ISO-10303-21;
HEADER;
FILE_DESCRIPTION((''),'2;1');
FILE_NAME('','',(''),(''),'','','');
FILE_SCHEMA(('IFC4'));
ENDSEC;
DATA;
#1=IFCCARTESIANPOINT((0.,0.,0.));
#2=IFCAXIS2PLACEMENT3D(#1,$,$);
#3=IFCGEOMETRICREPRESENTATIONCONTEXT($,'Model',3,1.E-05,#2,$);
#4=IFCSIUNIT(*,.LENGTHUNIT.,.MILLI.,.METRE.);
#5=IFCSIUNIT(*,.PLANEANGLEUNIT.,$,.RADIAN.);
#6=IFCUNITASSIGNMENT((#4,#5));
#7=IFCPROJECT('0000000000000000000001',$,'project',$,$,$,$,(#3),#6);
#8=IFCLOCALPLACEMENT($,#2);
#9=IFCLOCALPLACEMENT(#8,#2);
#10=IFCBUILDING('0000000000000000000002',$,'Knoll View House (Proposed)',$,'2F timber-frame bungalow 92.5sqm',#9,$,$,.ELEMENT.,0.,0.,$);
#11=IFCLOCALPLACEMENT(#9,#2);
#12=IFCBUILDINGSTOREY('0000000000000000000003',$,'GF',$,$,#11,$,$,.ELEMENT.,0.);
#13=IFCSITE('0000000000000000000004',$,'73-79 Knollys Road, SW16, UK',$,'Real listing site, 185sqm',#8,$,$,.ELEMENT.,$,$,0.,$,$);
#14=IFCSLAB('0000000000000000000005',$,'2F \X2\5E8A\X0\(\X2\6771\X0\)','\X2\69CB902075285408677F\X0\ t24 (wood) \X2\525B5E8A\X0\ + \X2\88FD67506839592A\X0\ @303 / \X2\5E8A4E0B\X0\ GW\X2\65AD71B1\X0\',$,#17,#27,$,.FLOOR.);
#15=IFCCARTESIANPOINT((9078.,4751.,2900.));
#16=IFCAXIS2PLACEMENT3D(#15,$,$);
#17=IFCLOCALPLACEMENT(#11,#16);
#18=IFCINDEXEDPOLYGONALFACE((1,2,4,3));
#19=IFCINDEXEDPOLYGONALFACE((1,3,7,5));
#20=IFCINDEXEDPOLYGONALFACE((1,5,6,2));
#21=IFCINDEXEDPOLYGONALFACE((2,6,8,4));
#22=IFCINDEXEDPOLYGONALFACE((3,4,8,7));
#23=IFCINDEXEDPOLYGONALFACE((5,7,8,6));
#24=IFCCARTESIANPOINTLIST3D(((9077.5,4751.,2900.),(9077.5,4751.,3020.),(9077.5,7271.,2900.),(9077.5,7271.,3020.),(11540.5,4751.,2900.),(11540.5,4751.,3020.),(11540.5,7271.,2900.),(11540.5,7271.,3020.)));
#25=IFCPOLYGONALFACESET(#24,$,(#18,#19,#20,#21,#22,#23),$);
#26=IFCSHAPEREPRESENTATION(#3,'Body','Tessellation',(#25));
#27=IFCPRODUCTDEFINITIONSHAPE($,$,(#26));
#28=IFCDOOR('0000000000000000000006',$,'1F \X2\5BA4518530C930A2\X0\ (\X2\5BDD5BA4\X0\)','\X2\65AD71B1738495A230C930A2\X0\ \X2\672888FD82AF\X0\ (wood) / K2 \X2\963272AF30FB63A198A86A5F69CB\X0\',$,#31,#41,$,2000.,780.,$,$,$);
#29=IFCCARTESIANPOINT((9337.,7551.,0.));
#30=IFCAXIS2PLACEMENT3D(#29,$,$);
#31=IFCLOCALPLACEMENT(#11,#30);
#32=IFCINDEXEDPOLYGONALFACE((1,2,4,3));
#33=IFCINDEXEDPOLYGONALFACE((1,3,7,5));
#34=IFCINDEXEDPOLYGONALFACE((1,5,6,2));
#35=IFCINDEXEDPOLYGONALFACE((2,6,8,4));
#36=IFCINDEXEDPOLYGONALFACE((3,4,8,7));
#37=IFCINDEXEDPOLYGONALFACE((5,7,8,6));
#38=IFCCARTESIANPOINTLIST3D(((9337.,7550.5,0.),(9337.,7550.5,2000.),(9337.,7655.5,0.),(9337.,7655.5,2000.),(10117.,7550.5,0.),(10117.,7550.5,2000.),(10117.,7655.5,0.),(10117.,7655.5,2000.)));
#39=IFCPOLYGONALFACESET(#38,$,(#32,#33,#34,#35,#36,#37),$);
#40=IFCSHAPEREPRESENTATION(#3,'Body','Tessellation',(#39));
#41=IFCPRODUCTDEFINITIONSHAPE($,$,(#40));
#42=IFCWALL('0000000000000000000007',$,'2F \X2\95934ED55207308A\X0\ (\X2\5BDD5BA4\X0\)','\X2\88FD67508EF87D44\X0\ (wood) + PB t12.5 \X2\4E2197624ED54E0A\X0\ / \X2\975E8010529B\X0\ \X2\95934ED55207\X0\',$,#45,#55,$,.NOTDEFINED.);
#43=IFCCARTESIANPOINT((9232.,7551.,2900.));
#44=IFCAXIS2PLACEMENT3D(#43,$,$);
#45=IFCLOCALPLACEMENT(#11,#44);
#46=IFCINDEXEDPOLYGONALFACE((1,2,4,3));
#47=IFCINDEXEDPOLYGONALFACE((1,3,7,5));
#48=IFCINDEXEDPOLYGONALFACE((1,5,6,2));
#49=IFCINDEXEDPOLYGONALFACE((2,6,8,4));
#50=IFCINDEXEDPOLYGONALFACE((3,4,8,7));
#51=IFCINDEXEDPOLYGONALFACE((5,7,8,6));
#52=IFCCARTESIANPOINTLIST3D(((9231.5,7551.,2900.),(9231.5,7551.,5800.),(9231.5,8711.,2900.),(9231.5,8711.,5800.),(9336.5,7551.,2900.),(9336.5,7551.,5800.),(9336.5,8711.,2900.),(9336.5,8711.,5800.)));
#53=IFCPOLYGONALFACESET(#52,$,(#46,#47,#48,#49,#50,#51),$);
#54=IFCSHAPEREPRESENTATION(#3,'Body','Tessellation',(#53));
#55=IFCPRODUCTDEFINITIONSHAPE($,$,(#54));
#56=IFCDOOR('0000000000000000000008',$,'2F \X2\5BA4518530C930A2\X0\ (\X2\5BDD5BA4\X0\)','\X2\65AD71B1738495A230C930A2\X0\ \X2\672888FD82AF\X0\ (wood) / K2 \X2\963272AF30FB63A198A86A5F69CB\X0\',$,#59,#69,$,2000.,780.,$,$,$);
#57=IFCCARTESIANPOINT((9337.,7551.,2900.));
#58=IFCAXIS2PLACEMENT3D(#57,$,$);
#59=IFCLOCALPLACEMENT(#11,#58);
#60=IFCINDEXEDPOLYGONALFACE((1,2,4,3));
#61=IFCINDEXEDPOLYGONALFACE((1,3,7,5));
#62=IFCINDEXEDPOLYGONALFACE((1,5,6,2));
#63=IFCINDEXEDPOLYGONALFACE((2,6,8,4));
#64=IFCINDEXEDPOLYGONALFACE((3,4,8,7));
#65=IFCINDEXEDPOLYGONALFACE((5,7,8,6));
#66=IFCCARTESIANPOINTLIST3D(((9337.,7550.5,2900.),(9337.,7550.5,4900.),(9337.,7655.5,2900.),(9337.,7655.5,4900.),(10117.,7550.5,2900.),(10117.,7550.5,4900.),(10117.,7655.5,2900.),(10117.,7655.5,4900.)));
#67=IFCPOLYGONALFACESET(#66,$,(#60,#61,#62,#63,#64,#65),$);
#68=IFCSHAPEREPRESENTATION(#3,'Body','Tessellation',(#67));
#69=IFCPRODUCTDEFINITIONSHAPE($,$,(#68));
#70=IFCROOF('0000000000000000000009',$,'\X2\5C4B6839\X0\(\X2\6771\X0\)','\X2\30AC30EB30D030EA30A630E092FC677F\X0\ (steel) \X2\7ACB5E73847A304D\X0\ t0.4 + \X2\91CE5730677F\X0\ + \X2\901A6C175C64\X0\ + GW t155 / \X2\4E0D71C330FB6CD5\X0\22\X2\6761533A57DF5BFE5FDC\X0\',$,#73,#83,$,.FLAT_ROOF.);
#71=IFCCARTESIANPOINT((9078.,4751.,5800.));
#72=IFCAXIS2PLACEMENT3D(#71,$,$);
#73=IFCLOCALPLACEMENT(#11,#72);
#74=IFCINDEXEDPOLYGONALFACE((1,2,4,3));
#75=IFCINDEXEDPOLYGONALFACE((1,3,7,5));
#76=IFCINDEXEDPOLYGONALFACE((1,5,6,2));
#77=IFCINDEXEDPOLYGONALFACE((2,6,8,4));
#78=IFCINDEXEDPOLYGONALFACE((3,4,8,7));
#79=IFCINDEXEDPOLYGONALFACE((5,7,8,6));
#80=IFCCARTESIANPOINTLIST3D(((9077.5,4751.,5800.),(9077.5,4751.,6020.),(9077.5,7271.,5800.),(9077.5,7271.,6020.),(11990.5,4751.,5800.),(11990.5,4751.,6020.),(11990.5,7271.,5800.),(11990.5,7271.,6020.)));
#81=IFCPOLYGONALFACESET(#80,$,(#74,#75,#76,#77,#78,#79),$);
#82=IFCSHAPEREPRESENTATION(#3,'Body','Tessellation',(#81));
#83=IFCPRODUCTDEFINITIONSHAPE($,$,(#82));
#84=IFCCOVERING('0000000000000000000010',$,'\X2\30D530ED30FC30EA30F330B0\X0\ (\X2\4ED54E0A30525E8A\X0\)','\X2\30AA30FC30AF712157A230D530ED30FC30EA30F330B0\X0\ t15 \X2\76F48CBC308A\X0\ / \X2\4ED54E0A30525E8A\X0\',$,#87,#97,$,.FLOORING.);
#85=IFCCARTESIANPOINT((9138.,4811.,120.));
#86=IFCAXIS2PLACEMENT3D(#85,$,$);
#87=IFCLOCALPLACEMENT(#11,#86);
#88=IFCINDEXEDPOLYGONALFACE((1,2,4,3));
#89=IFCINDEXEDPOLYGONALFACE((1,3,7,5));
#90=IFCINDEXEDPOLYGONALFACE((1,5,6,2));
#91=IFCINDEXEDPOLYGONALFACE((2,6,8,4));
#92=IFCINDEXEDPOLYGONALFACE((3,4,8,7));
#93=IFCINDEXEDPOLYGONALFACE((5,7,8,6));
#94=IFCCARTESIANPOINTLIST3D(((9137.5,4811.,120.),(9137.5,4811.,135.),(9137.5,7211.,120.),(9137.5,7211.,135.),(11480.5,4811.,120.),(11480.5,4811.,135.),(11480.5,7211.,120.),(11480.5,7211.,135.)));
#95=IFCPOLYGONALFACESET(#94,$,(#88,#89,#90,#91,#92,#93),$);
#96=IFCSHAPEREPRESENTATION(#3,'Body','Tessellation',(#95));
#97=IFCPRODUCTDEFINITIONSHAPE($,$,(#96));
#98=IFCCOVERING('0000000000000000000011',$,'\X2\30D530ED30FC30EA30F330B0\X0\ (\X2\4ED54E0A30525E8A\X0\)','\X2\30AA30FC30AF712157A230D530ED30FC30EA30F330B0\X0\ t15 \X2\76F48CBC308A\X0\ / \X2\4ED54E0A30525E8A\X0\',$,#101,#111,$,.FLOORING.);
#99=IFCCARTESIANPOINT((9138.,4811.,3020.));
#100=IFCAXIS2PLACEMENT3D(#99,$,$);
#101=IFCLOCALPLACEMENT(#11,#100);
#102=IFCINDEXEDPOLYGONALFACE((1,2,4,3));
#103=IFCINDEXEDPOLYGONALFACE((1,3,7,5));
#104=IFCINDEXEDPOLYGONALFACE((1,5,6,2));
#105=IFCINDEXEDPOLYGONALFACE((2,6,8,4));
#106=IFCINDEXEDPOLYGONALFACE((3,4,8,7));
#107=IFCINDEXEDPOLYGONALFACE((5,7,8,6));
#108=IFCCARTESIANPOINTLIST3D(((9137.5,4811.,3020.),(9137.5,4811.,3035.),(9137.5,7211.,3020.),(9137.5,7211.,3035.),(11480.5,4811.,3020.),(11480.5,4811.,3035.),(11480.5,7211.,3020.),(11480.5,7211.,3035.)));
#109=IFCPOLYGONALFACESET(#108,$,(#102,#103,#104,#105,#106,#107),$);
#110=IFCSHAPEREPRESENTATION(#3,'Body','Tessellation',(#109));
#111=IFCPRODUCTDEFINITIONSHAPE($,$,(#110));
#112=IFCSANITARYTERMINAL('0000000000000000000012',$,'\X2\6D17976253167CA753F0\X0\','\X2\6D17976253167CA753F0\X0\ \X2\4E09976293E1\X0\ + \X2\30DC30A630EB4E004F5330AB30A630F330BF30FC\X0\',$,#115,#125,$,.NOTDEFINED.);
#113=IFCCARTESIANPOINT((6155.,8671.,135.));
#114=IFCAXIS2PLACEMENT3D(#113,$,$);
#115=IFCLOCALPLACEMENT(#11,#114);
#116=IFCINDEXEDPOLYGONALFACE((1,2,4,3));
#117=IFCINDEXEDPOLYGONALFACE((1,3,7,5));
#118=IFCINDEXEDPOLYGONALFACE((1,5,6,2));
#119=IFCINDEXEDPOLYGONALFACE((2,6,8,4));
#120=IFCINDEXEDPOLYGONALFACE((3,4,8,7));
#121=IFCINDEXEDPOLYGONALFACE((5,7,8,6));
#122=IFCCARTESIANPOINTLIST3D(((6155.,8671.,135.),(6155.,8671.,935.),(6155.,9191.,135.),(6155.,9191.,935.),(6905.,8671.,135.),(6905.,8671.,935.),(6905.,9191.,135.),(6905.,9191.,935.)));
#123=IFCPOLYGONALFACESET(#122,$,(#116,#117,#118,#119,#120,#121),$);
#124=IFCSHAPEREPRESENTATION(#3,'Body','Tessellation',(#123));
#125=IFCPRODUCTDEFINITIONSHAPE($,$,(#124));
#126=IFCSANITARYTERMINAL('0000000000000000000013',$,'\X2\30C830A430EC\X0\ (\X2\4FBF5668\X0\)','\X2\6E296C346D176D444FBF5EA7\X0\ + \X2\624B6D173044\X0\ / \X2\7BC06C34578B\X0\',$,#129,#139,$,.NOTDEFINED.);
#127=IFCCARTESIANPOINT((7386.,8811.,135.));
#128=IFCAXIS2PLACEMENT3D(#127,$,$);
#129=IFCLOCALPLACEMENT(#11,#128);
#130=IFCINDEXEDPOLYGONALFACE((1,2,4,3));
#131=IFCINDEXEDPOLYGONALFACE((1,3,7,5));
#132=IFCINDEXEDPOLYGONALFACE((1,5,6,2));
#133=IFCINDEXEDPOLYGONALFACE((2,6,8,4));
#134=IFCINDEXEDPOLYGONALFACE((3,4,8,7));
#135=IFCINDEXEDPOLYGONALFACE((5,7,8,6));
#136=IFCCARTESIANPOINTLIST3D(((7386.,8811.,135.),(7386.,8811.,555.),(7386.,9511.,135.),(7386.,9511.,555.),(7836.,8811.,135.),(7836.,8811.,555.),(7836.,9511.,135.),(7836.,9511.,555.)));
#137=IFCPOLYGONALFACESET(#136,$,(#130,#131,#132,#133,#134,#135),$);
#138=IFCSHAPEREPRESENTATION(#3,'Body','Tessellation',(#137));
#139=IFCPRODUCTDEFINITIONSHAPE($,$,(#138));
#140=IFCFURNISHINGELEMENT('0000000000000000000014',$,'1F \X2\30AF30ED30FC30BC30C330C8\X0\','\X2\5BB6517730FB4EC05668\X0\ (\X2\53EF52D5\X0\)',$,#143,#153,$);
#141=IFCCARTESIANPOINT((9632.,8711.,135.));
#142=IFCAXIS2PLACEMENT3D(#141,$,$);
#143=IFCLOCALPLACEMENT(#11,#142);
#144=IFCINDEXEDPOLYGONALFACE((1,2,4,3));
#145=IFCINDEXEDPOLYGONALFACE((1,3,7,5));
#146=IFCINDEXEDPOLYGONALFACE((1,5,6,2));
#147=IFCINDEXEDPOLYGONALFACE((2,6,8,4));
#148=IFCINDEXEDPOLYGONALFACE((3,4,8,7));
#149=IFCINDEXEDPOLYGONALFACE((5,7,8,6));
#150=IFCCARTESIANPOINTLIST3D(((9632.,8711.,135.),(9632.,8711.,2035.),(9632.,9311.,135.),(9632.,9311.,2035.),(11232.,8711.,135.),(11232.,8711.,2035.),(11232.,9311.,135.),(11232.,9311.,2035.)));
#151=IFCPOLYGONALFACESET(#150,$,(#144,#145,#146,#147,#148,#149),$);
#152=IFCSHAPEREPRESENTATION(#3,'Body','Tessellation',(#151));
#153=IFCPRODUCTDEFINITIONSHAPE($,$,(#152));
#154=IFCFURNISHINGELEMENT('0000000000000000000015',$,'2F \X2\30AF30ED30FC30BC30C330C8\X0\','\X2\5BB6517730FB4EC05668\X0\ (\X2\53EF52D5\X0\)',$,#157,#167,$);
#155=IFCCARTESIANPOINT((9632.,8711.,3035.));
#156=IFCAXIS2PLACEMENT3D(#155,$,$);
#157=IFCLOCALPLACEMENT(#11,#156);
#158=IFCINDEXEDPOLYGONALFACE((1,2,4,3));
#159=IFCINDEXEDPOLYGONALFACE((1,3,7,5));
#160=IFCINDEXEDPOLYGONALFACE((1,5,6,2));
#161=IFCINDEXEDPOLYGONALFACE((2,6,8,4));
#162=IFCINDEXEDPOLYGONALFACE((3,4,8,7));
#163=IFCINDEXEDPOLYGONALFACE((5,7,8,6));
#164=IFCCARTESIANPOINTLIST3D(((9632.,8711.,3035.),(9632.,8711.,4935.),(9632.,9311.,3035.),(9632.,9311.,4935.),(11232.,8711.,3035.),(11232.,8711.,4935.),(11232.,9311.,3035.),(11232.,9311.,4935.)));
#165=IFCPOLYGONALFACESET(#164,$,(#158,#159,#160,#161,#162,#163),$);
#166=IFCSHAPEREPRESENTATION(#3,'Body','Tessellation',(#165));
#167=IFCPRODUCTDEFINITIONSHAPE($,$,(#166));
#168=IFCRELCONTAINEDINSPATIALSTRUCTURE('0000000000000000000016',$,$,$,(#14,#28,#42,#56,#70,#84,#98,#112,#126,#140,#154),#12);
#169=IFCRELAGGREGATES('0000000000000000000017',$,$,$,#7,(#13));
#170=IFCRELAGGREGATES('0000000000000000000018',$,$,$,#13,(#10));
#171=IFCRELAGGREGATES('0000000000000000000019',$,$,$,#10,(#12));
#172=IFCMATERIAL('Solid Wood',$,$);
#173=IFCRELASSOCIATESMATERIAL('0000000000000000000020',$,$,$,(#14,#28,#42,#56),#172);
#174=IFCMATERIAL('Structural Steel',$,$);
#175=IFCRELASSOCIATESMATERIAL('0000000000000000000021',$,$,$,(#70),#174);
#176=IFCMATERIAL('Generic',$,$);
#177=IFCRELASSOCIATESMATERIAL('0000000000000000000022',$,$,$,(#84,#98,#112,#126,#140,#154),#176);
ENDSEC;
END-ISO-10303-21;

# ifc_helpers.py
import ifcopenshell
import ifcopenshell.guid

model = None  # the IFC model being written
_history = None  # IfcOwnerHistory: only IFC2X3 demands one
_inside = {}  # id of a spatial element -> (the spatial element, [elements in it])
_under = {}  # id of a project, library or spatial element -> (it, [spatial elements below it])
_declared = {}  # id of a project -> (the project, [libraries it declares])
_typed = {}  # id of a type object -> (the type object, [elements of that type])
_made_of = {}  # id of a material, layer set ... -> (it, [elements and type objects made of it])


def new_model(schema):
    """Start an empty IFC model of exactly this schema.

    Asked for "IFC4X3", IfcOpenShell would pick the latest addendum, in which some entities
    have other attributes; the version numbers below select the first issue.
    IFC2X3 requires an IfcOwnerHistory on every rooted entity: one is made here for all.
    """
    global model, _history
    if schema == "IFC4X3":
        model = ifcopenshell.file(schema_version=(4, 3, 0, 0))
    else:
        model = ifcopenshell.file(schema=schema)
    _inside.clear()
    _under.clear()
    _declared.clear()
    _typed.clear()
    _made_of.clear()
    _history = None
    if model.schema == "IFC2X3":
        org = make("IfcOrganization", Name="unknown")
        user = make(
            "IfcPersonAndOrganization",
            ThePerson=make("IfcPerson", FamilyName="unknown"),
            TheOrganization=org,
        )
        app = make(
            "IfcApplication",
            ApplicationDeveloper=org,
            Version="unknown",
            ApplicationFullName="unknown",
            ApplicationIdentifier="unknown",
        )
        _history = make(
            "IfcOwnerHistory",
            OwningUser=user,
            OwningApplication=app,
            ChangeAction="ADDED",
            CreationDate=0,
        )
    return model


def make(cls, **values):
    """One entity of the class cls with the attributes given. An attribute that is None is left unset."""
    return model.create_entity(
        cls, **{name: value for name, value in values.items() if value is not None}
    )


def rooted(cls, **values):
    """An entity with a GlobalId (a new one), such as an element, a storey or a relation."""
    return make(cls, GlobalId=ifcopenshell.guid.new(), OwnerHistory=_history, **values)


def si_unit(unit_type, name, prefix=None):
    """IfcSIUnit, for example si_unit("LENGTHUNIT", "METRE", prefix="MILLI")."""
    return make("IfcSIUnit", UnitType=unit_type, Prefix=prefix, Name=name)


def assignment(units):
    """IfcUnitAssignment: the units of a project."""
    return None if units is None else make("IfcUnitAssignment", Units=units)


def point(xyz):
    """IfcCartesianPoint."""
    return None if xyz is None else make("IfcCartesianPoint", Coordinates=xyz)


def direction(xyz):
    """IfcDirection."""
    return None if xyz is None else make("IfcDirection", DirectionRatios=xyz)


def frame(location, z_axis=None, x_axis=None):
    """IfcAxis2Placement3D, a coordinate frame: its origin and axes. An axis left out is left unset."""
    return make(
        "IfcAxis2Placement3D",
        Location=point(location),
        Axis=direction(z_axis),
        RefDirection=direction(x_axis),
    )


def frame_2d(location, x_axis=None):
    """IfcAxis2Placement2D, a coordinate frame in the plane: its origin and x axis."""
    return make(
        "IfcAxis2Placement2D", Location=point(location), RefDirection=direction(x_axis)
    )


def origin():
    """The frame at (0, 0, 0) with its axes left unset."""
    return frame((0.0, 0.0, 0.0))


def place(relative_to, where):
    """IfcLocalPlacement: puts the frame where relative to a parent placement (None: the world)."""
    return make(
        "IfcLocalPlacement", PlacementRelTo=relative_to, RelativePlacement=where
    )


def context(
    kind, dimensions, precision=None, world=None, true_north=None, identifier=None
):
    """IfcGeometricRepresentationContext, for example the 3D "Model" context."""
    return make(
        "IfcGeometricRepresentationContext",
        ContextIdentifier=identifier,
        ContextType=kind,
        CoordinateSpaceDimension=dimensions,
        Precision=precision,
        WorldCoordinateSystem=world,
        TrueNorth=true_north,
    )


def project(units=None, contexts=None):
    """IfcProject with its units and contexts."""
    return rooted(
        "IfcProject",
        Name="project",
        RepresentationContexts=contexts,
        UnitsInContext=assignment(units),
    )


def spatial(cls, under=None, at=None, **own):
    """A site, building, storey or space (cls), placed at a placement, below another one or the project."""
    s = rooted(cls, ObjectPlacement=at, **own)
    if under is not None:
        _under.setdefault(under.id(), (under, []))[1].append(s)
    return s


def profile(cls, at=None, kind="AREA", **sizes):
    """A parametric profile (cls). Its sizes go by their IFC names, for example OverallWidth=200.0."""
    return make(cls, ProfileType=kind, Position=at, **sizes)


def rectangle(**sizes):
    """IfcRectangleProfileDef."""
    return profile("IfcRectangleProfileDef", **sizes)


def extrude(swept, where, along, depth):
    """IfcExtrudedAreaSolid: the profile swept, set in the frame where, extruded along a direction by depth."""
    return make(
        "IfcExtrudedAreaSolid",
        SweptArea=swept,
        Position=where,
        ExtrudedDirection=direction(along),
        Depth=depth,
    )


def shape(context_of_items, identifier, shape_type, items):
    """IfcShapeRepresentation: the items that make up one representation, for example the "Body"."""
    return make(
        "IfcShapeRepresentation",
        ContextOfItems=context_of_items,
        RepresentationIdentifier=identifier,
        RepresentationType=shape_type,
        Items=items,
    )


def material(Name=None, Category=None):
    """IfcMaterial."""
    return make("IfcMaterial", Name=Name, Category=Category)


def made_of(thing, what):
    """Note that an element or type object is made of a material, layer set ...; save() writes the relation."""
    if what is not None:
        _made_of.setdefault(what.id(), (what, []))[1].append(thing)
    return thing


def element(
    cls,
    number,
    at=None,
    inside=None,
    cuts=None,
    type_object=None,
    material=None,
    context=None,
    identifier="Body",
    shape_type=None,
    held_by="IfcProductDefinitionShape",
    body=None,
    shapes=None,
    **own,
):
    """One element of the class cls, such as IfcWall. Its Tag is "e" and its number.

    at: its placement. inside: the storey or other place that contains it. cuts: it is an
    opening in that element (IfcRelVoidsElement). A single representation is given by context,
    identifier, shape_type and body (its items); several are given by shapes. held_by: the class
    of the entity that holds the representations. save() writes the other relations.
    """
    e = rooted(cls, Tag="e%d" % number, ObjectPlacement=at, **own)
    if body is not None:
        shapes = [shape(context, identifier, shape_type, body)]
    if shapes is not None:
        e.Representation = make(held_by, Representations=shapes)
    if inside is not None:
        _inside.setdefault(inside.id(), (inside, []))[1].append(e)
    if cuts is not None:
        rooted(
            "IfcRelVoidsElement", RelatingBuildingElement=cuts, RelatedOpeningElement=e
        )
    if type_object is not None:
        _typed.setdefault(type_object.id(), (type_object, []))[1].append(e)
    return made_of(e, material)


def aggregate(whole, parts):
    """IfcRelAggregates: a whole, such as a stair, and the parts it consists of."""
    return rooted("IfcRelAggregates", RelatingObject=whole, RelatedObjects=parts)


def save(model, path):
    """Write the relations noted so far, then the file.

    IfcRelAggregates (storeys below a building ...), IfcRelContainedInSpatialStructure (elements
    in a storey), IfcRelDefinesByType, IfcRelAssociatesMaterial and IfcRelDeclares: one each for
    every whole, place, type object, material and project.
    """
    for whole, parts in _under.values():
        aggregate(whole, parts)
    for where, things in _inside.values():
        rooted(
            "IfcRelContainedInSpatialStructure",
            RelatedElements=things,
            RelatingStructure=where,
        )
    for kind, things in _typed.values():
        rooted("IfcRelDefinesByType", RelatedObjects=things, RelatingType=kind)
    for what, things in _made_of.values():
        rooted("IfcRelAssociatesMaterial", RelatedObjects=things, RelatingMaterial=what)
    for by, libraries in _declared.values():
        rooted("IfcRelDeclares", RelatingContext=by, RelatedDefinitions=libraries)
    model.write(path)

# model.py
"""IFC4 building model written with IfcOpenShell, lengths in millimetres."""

from ifc_helpers import new_model, si_unit, frame, frame_2d, origin, place, context, project, spatial, rectangle, extrude, material, element, save


model = new_model("IFC4")

# Units and contexts
model_context = context("Model", 3, precision=1e-05, world=origin())
ifc_project = project(units=[si_unit("LENGTHUNIT", "METRE", prefix="MILLI"), si_unit("PLANEANGLEUNIT", "RADIAN")], contexts=[model_context])

# Site, building, storey
site_placement = place(None, origin())
site = spatial("IfcSite", under=ifc_project, at=site_placement, Name="73-79 Knollys Road, SW16, UK", ObjectType="Real listing site, 185sqm", CompositionType="ELEMENT", RefElevation=0.0)
building_placement = place(site_placement, origin())
building = spatial("IfcBuilding", under=site, at=building_placement, Name="Knoll View House (Proposed)", ObjectType="2F timber-frame bungalow 92.5sqm", CompositionType="ELEMENT", ElevationOfRefHeight=0.0, ElevationOfTerrain=0.0)
storey_placement = place(building_placement, origin())
storey = spatial("IfcBuildingStorey", under=building, at=storey_placement, Name="GF", CompositionType="ELEMENT", Elevation=0.0)

# Slab
ifc_material_1 = material(Name="Solid Wood")
slab_1_placement = place(storey_placement, frame((9078.0, 4751.0, 2900.0)))
element("IfcSlab", 1, at=slab_1_placement, inside=storey, material=ifc_material_1, Name="2F 床(東)", Description="構造用合板 t24 (wood) 剛床 + 製材根太 @303 / 床下 GW断熱", PredefinedType="FLOOR", context=model_context, shape_type="SweptSolid", body=[
    extrude(rectangle(XDim=2463.0, YDim=2520.0, at=frame_2d((1231.0, 1260.0))), frame((9078.0, 4751.0, 2900.0)), (0.0, 0.0, 1.0), 120.0),
])

# Door
door_1_placement = place(storey_placement, frame((9337.0, 7551.0, 0.0)))
element("IfcDoor", 2, at=door_1_placement, inside=storey, material=ifc_material_1, Name="1F 室内ドア (寝室)", Description="断熱玄関ドア 木製芯 (wood) / K2 防犯・採風機構", OverallHeight=2000.0, OverallWidth=780.0, context=model_context, shape_type="SweptSolid", body=[
    extrude(rectangle(XDim=780.0, YDim=105.0, at=frame_2d((390.0, 52.0))), frame((9337.0, 7551.0, 0.0)), (0.0, 0.0, 1.0), 2000.0),
])

# Wall
wall_1_placement = place(storey_placement, frame((9232.0, 7551.0, 2900.0)))
element("IfcWall", 3, at=wall_1_placement, inside=storey, material=ifc_material_1, Name="2F 間仕切り (寝室)", Description="製材軸組 (wood) + PB t12.5 両面仕上 / 非耐力 間仕切", PredefinedType="NOTDEFINED", context=model_context, shape_type="SweptSolid", body=[
    extrude(rectangle(XDim=105.0, YDim=1160.0, at=frame_2d((52.0, 580.0))), frame((9232.0, 7551.0, 2900.0)), (0.0, 0.0, 1.0), 2900.0),
])

# Door
door_2_placement = place(storey_placement, frame((9337.0, 7551.0, 2900.0)))
element("IfcDoor", 4, at=door_2_placement, inside=storey, material=ifc_material_1, Name="2F 室内ドア (寝室)", Description="断熱玄関ドア 木製芯 (wood) / K2 防犯・採風機構", OverallHeight=2000.0, OverallWidth=780.0, context=model_context, shape_type="SweptSolid", body=[
    extrude(rectangle(XDim=780.0, YDim=105.0, at=frame_2d((390.0, 52.0))), frame((9337.0, 7551.0, 2900.0)), (0.0, 0.0, 1.0), 2000.0),
])

# Roof
ifc_material_2 = material(Name="Structural Steel")
for number, where, name in (
    (5, (9078.0, 4751.0, 5800.0), "屋根(東)"),
):
    element("IfcRoof", number, at=place(storey_placement, frame(where)), inside=storey, material=ifc_material_2, Name=name, Description="ガルバリウム鋼板 (steel) 立平葺き t0.4 + 野地板 + 通気層 + GW t155 / 不燃・法22条区域対応", PredefinedType="FLAT_ROOF", context=model_context, shape_type="SweptSolid", body=[
        extrude(rectangle(XDim=2913.0, YDim=2520.0, at=frame_2d((1456.0, 1260.0))), frame((9078.0, 4751.0, 5800.0)), (0.0, 0.0, 1.0), 220.0),
    ])

# Coverings
ifc_material_3 = material(Name="Generic")
covering_1_placement = place(storey_placement, frame((9138.0, 4811.0, 120.0)))
element("IfcCovering", 6, at=covering_1_placement, inside=storey, material=ifc_material_3, Name="フローリング (仕上げ床)", Description="オーク無垢フローリング t15 直貼り / 仕上げ床", PredefinedType="FLOORING", context=model_context, shape_type="SweptSolid", body=[
    extrude(rectangle(XDim=2343.0, YDim=2400.0, at=frame_2d((1171.0, 1200.0))), frame((9138.0, 4811.0, 120.0)), (0.0, 0.0, 1.0), 15.0),
])
covering_2_placement = place(storey_placement, frame((9138.0, 4811.0, 3020.0)))
element("IfcCovering", 7, at=covering_2_placement, inside=storey, material=ifc_material_3, Name="フローリング (仕上げ床)", Description="オーク無垢フローリング t15 直貼り / 仕上げ床", PredefinedType="FLOORING", context=model_context, shape_type="SweptSolid", body=[
    extrude(rectangle(XDim=2343.0, YDim=2400.0, at=frame_2d((1171.0, 1200.0))), frame((9138.0, 4811.0, 3020.0)), (0.0, 0.0, 1.0), 15.0),
])

# Sanitary terminals
sanitary_terminal_1_placement = place(storey_placement, frame((6155.0, 8671.0, 135.0)))
element("IfcSanitaryTerminal", 8, at=sanitary_terminal_1_placement, inside=storey, material=ifc_material_3, Name="洗面化粧台", Description="洗面化粧台 三面鏡 + ボウル一体カウンター", PredefinedType="NOTDEFINED", context=model_context, shape_type="SweptSolid", body=[
    extrude(rectangle(XDim=750.0, YDim=520.0, at=frame_2d((375.0, 260.0))), frame((6155.0, 8671.0, 135.0)), (0.0, 0.0, 1.0), 800.0),
])
sanitary_terminal_2_placement = place(storey_placement, frame((7386.0, 8811.0, 135.0)))
element("IfcSanitaryTerminal", 9, at=sanitary_terminal_2_placement, inside=storey, material=ifc_material_3, Name="トイレ (便器)", Description="温水洗浄便座 + 手洗い / 節水型", PredefinedType="NOTDEFINED", context=model_context, shape_type="SweptSolid", body=[
    extrude(rectangle(XDim=450.0, YDim=700.0, at=frame_2d((225.0, 350.0))), frame((7386.0, 8811.0, 135.0)), (0.0, 0.0, 1.0), 420.0),
])

# Furnishing elements
furnishing_1_placement = place(storey_placement, frame((9632.0, 8711.0, 135.0)))
element("IfcFurnishingElement", 10, at=furnishing_1_placement, inside=storey, material=ifc_material_3, Name="1F クローゼット", Description="家具・什器 (可動)", context=model_context, shape_type="SweptSolid", body=[
    extrude(rectangle(XDim=1600.0, YDim=600.0, at=frame_2d((800.0, 300.0))), frame((9632.0, 8711.0, 135.0)), (0.0, 0.0, 1.0), 1900.0),
])
furnishing_2_placement = place(storey_placement, frame((9632.0, 8711.0, 3035.0)))
element("IfcFurnishingElement", 11, at=furnishing_2_placement, inside=storey, material=ifc_material_3, Name="2F クローゼット", Description="家具・什器 (可動)", context=model_context, shape_type="SweptSolid", body=[
    extrude(rectangle(XDim=1600.0, YDim=600.0, at=frame_2d((800.0, 300.0))), frame((9632.0, 8711.0, 3035.0)), (0.0, 0.0, 1.0), 1900.0),
])

save(model, "model.ifc")
